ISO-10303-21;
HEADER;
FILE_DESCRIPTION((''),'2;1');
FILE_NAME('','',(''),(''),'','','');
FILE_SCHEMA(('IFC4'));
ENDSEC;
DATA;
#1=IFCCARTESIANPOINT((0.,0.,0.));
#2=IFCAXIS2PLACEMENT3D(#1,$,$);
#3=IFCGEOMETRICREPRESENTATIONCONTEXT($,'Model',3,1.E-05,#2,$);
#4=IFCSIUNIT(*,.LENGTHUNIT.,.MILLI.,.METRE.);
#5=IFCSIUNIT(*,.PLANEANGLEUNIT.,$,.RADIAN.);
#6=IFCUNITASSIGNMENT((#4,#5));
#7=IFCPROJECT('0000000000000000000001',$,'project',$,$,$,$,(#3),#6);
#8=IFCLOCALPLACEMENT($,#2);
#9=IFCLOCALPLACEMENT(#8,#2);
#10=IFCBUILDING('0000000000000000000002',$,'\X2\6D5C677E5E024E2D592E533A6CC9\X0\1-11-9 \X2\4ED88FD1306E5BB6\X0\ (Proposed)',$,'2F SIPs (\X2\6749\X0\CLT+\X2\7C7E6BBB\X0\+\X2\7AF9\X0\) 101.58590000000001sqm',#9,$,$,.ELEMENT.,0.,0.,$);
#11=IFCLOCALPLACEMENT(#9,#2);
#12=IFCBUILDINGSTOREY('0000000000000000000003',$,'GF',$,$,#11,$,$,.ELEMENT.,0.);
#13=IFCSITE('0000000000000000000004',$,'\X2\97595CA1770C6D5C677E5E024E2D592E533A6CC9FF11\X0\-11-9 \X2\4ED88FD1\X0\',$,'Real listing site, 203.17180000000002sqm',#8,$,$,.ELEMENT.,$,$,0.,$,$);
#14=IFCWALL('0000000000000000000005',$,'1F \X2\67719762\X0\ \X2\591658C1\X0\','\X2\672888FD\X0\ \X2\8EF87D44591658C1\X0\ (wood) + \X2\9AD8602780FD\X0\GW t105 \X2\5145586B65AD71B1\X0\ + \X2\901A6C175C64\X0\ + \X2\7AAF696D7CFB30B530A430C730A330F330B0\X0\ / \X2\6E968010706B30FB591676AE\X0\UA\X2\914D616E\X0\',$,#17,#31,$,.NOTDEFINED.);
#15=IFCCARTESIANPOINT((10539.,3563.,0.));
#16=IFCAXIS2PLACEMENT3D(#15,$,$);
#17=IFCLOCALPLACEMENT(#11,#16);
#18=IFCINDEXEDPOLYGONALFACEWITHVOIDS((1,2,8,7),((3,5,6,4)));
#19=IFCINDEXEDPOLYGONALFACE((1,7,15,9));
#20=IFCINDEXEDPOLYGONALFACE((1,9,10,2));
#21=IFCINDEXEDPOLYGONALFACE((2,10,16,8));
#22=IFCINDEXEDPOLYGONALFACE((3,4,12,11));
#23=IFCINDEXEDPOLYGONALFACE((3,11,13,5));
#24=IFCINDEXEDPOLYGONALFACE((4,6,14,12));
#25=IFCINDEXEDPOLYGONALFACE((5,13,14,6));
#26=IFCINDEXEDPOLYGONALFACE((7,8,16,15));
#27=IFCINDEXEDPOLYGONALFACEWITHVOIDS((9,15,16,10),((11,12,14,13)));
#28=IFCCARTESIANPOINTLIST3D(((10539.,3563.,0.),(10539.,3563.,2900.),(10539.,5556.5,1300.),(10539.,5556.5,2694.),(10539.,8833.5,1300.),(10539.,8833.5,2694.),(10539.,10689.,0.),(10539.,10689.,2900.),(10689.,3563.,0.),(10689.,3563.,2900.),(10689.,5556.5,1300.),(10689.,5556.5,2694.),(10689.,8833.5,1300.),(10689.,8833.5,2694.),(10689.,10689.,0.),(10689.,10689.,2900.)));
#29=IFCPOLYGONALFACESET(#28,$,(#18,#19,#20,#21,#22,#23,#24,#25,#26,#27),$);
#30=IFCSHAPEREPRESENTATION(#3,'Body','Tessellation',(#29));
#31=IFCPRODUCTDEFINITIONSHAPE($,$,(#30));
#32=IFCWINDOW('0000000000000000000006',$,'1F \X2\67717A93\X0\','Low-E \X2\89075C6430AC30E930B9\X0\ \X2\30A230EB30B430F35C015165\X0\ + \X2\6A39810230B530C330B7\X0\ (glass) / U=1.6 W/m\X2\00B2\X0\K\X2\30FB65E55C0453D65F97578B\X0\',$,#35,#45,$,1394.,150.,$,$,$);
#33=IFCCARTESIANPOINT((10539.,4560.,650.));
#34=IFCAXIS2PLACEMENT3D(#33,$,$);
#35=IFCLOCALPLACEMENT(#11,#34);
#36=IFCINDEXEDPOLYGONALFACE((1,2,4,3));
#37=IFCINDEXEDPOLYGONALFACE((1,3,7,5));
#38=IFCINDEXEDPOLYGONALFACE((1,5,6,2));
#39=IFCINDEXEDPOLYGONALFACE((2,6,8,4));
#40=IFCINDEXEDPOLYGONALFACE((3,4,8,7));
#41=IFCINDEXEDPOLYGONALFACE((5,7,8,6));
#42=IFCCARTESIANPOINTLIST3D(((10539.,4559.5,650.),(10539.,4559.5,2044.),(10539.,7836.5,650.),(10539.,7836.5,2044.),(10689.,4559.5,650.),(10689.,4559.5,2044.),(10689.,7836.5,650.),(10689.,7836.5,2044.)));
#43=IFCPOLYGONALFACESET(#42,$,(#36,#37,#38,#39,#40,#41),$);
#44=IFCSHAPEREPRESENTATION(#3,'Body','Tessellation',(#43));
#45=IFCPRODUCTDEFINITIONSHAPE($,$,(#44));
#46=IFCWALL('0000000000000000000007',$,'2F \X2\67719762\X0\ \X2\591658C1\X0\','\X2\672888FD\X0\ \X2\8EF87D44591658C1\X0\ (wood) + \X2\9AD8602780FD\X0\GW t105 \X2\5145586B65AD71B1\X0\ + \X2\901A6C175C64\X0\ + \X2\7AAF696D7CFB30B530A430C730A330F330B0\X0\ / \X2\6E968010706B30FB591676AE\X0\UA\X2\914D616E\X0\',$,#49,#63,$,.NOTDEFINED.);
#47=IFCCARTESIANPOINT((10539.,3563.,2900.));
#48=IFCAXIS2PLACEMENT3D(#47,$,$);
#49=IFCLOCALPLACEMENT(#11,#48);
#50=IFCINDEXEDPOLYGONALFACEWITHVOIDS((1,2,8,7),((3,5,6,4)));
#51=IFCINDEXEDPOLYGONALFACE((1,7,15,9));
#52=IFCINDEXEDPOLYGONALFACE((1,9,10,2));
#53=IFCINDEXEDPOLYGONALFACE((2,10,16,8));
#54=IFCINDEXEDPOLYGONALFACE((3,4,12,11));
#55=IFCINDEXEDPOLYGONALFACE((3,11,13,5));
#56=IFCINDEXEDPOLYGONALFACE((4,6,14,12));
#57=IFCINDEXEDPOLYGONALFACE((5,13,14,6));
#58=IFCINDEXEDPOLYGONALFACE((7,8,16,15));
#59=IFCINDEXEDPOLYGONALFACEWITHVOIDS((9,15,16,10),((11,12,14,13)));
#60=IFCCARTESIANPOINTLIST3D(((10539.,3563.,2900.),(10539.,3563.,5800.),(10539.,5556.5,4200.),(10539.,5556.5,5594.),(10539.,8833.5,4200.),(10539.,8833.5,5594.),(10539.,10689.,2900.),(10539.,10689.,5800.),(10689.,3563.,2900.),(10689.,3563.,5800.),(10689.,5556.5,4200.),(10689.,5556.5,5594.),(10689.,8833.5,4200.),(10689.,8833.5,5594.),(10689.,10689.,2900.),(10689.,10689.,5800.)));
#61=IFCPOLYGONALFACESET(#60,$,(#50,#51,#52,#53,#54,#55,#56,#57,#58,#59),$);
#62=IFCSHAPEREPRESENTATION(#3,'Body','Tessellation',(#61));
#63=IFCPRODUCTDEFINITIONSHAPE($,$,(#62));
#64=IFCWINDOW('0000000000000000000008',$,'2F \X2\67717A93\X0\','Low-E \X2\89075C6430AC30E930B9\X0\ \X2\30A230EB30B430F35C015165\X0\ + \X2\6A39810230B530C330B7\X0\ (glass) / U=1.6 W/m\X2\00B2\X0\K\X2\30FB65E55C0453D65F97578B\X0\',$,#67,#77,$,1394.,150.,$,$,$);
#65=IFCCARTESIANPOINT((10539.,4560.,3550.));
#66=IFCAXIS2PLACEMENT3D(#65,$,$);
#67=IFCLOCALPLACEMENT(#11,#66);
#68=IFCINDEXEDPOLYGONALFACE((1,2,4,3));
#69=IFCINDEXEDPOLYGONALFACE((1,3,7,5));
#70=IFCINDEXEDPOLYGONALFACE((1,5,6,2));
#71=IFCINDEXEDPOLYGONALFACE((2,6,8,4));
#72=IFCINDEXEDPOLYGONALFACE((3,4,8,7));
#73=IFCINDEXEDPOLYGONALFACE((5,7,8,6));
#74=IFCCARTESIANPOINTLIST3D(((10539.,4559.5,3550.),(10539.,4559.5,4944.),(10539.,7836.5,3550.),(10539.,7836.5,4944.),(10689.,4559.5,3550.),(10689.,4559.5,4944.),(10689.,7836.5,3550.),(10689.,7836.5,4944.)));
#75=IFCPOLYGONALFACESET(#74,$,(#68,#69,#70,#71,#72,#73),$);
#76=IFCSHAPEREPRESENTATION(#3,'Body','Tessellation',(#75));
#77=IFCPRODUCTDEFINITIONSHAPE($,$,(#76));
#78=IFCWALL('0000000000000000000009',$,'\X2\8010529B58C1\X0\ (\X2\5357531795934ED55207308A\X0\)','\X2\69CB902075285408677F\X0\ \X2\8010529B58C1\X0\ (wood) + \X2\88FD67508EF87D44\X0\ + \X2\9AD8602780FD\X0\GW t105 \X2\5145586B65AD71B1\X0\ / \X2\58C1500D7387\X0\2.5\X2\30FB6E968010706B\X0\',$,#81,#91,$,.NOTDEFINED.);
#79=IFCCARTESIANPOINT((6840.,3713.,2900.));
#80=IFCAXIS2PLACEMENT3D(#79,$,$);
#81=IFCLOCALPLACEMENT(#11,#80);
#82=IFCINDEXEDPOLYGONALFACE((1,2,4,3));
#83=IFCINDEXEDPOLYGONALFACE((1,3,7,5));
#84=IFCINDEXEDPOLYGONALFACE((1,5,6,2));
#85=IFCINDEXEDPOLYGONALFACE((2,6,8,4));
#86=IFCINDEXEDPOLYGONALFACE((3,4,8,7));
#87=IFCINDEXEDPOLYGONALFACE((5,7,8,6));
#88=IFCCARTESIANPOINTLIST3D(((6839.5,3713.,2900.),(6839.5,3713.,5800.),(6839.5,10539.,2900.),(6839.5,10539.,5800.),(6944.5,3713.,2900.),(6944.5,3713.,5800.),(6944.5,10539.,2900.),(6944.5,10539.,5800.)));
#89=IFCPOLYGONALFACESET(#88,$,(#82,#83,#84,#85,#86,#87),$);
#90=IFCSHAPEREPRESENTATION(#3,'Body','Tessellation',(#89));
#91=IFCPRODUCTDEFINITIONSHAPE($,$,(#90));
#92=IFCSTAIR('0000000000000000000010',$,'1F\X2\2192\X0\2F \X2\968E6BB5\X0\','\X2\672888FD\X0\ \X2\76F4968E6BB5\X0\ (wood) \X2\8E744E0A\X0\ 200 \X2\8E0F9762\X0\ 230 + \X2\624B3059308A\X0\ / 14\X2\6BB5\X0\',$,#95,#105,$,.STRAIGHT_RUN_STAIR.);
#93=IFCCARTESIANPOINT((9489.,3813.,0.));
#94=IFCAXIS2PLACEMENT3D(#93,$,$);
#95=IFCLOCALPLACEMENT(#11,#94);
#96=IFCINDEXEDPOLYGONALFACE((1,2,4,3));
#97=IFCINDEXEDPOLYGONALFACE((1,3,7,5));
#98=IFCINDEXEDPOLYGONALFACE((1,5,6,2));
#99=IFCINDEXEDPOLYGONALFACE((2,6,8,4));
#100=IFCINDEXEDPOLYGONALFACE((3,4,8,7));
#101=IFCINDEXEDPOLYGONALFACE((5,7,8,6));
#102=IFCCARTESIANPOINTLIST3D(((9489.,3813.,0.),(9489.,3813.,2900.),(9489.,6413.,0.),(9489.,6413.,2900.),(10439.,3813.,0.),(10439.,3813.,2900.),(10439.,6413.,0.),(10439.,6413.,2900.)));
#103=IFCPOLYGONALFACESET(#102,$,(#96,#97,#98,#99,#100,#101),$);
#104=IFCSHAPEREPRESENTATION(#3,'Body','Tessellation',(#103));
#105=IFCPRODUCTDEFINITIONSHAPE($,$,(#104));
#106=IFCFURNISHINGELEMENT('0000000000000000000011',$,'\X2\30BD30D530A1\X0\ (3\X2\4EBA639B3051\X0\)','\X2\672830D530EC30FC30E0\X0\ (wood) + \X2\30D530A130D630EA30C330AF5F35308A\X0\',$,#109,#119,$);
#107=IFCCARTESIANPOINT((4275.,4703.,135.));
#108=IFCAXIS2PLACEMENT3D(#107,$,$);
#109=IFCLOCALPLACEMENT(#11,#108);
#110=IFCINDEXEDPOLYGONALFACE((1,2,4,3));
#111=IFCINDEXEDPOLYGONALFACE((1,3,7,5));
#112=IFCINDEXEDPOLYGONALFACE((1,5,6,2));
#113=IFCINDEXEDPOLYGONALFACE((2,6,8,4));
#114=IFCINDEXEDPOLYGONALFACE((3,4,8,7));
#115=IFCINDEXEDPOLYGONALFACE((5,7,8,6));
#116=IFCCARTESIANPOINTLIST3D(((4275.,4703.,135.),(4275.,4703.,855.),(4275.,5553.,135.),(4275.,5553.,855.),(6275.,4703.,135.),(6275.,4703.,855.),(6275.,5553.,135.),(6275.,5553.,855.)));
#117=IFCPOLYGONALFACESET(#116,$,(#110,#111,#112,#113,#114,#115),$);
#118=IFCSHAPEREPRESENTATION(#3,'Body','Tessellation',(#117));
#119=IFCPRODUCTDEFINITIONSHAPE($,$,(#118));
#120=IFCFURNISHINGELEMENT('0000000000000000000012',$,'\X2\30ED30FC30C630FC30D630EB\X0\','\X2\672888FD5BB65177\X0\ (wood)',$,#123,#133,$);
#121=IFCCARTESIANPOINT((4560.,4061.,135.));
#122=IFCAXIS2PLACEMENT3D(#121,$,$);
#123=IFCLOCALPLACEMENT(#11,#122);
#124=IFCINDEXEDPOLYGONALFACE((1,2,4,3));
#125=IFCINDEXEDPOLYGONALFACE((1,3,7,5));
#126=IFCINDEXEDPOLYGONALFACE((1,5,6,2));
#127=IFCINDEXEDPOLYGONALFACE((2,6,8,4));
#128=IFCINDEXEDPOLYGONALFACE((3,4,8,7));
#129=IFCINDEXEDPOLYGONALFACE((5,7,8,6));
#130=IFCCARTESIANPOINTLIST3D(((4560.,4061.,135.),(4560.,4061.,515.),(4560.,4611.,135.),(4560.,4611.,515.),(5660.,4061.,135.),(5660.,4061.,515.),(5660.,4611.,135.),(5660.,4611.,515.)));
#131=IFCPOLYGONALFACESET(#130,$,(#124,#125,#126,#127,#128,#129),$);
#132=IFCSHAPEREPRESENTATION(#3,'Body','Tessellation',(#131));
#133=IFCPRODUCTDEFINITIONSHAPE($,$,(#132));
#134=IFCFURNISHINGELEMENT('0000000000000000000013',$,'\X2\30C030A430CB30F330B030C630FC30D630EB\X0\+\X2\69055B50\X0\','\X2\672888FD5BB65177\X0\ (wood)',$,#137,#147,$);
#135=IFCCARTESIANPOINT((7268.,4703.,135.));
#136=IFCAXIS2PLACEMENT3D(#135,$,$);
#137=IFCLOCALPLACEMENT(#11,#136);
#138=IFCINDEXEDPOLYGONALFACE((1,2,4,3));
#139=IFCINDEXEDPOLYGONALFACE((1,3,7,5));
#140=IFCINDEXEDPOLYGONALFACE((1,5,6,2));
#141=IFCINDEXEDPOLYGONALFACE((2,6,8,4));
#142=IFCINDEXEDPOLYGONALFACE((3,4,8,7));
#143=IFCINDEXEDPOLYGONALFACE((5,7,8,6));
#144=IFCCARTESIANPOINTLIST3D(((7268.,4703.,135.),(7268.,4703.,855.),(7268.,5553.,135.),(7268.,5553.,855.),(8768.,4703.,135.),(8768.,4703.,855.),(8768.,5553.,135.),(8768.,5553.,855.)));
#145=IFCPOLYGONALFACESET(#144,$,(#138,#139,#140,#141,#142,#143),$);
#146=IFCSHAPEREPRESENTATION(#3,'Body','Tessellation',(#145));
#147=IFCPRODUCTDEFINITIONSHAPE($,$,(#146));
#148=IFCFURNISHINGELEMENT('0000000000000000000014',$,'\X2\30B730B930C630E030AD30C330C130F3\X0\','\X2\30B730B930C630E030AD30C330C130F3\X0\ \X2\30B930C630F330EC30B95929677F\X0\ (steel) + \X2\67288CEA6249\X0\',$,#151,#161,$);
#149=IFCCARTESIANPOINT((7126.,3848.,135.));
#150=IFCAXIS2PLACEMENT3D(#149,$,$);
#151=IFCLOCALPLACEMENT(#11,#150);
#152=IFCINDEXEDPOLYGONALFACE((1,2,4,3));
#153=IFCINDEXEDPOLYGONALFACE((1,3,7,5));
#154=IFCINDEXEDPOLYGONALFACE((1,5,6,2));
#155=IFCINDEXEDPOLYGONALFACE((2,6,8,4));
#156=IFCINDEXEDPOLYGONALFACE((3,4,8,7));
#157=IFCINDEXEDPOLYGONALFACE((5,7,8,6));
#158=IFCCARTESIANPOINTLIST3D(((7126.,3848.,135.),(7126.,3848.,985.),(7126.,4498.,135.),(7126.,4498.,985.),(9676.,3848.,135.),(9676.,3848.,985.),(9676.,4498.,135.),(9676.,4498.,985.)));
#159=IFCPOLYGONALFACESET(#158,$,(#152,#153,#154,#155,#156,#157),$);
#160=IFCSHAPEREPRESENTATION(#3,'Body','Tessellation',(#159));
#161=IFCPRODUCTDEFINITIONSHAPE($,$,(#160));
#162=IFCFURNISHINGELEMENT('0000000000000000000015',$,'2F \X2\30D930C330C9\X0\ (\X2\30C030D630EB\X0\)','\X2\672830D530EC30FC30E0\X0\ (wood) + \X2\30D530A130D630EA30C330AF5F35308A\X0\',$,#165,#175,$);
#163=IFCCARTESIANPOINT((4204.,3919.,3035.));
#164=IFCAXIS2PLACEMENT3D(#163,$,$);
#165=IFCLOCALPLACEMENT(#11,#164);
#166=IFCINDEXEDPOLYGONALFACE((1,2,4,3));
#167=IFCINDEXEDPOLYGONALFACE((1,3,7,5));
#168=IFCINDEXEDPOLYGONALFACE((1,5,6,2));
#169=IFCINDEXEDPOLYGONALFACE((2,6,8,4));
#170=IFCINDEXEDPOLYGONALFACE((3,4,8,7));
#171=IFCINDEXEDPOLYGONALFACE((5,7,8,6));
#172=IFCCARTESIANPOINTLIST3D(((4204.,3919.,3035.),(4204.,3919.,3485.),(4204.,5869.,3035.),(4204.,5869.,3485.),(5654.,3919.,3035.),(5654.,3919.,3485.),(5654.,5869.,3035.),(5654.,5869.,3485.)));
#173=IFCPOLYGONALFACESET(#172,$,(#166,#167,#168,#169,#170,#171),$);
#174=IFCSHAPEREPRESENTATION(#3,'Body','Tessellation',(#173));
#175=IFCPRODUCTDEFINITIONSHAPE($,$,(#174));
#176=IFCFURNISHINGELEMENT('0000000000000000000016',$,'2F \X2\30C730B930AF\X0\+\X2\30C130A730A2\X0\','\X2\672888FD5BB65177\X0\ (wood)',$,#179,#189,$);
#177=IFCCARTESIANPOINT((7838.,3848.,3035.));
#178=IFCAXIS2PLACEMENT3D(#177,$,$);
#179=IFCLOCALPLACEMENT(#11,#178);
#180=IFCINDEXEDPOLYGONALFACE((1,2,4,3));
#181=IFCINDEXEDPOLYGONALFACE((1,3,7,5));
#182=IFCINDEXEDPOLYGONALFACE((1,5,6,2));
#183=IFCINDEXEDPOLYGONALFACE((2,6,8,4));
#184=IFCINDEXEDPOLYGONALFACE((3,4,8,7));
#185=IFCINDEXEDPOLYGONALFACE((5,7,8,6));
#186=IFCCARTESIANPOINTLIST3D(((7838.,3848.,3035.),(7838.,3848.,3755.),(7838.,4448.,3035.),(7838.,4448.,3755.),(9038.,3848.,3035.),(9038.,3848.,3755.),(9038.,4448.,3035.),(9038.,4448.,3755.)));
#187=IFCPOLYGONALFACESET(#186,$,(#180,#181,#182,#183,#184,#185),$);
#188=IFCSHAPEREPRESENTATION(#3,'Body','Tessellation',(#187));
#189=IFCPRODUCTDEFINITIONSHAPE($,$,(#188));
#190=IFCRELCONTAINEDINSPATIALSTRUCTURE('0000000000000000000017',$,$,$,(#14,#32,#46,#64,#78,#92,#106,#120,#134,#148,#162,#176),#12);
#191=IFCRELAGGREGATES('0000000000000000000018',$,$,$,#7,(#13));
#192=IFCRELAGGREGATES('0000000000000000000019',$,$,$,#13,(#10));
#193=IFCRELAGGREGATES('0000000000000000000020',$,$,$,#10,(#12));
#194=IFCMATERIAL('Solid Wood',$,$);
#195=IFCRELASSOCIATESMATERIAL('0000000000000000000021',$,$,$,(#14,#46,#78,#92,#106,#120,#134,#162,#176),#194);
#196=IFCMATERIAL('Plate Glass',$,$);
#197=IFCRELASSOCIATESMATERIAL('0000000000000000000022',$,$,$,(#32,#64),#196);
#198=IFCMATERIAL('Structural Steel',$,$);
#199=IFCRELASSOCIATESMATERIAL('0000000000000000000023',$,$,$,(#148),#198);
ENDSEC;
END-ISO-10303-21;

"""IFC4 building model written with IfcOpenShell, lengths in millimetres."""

from ifc_helpers import new_model, si_unit, frame, frame_2d, origin, place, context, project, spatial, rectangle, extrude, material, element, fill, save


model = new_model("IFC4")

# Units and contexts
model_context = context("Model", 3, precision=1e-05, world=origin())
ifc_project = project(units=[si_unit("LENGTHUNIT", "METRE", prefix="MILLI"), si_unit("PLANEANGLEUNIT", "RADIAN")], contexts=[model_context])

# Site, building, storey
site_placement = place(None, origin())
site = spatial("IfcSite", under=ifc_project, at=site_placement, Name="静岡県浜松市中央区泉１-11-9 付近", ObjectType="Real listing site, 203.17180000000002sqm", CompositionType="ELEMENT", RefElevation=0.0)
building_placement = place(site_placement, origin())
building = spatial("IfcBuilding", under=site, at=building_placement, Name="浜松市中央区泉1-11-9 付近の家 (Proposed)", ObjectType="2F SIPs (杉CLT+籾殻+竹) 101.58590000000001sqm", CompositionType="ELEMENT", ElevationOfRefHeight=0.0, ElevationOfTerrain=0.0)
storey_placement = place(building_placement, origin())
storey = spatial("IfcBuildingStorey", under=building, at=storey_placement, Name="GF", CompositionType="ELEMENT", Elevation=0.0)

# Wall, opening, window
ifc_material_1 = material(Name="Solid Wood")
wall_1_placement = place(storey_placement, frame((10539.0, 3563.0, 0.0)))
wall_1 = element("IfcWall", 1, at=wall_1_placement, inside=storey, material=ifc_material_1, Name="1F 東面 外壁", Description="木製 軸組外壁 (wood) + 高性能GW t105 充填断熱 + 通気層 + 窯業系サイディング / 準耐火・外皮UA配慮", PredefinedType="NOTDEFINED", context=model_context, shape_type="SweptSolid", body=[
    extrude(rectangle(XDim=150.0, YDim=7126.0, at=frame_2d((75.0, 3563.0))), frame((10539.0, 3563.0, 0.0)), (0.0, 0.0, 1.0), 2900.0),
])
opening_1_placement = place(storey_placement, frame((10539.0, 4560.0, 650.0)))
opening_1 = element("IfcOpeningElement", 2, at=opening_1_placement, cuts=wall_1, PredefinedType="NOTDEFINED", context=model_context, shape_type="SweptSolid", body=[
    extrude(rectangle(XDim=150.0, YDim=3277.0, at=frame_2d((75.0, 1638.0))), frame((10539.0, 4560.0, 650.0)), (0.0, 0.0, 1.0), 1394.0),
])
ifc_material_2 = material(Name="Plate Glass")
window_1_placement = place(storey_placement, frame((10539.0, 4560.0, 650.0)))
window_1 = element("IfcWindow", 3, at=window_1_placement, inside=storey, material=ifc_material_2, Name="1F 東窓", Description="Low-E 複層ガラス アルゴン封入 + 樹脂サッシ (glass) / U=1.6 W/m²K・日射取得型", OverallHeight=1394.0, OverallWidth=150.0, context=model_context, shape_type="SweptSolid", body=[
    extrude(rectangle(XDim=150.0, YDim=3277.0, at=frame_2d((75.0, 1638.0))), frame((10539.0, 4560.0, 650.0)), (0.0, 0.0, 1.0), 1394.0),
])
fill(opening_1, window_1)

# Wall, opening, window
wall_2_placement = place(storey_placement, frame((10539.0, 3563.0, 2900.0)))
wall_2 = element("IfcWall", 4, at=wall_2_placement, inside=storey, material=ifc_material_1, Name="2F 東面 外壁", Description="木製 軸組外壁 (wood) + 高性能GW t105 充填断熱 + 通気層 + 窯業系サイディング / 準耐火・外皮UA配慮", PredefinedType="NOTDEFINED", context=model_context, shape_type="SweptSolid", body=[
    extrude(rectangle(XDim=150.0, YDim=7126.0, at=frame_2d((75.0, 3563.0))), frame((10539.0, 3563.0, 2900.0)), (0.0, 0.0, 1.0), 2900.0),
])
opening_2_placement = place(storey_placement, frame((10539.0, 4560.0, 3550.0)))
opening_2 = element("IfcOpeningElement", 5, at=opening_2_placement, cuts=wall_2, PredefinedType="NOTDEFINED", context=model_context, shape_type="SweptSolid", body=[
    extrude(rectangle(XDim=150.0, YDim=3277.0, at=frame_2d((75.0, 1638.0))), frame((10539.0, 4560.0, 3550.0)), (0.0, 0.0, 1.0), 1394.0),
])
window_2_placement = place(storey_placement, frame((10539.0, 4560.0, 3550.0)))
window_2 = element("IfcWindow", 6, at=window_2_placement, inside=storey, material=ifc_material_2, Name="2F 東窓", Description="Low-E 複層ガラス アルゴン封入 + 樹脂サッシ (glass) / U=1.6 W/m²K・日射取得型", OverallHeight=1394.0, OverallWidth=150.0, context=model_context, shape_type="SweptSolid", body=[
    extrude(rectangle(XDim=150.0, YDim=3277.0, at=frame_2d((75.0, 1638.0))), frame((10539.0, 4560.0, 3550.0)), (0.0, 0.0, 1.0), 1394.0),
])
fill(opening_2, window_2)

# Wall
wall_3_placement = place(storey_placement, frame((6840.0, 3713.0, 2900.0)))
element("IfcWall", 7, at=wall_3_placement, inside=storey, material=ifc_material_1, Name="耐力壁 (南北間仕切り)", Description="構造用合板 耐力壁 (wood) + 製材軸組 + 高性能GW t105 充填断熱 / 壁倍率2.5・準耐火", PredefinedType="NOTDEFINED", context=model_context, shape_type="SweptSolid", body=[
    extrude(rectangle(XDim=105.0, YDim=6826.0, at=frame_2d((52.0, 3413.0))), frame((6840.0, 3713.0, 2900.0)), (0.0, 0.0, 1.0), 2900.0),
])

# Stair
stair_placement = place(storey_placement, frame((9489.0, 3813.0, 0.0)))
element("IfcStair", 8, at=stair_placement, inside=storey, material=ifc_material_1, Name="1F→2F 階段", Description="木製 直階段 (wood) 蹴上 200 踏面 230 + 手すり / 14段", PredefinedType="STRAIGHT_RUN_STAIR", context=model_context, shape_type="SweptSolid", body=[
    extrude(rectangle(XDim=950.0, YDim=2600.0, at=frame_2d((475.0, 1300.0))), frame((9489.0, 3813.0, 0.0)), (0.0, 0.0, 1.0), 2900.0),
])

# Furnishing elements
furnishing_1_placement = place(storey_placement, frame((4275.0, 4703.0, 135.0)))
element("IfcFurnishingElement", 9, at=furnishing_1_placement, inside=storey, material=ifc_material_1, Name="ソファ (3人掛け)", Description="木フレーム (wood) + ファブリック張り", context=model_context, shape_type="SweptSolid", body=[
    extrude(rectangle(XDim=2000.0, YDim=850.0, at=frame_2d((1000.0, 425.0))), frame((4275.0, 4703.0, 135.0)), (0.0, 0.0, 1.0), 720.0),
])
furnishing_2_placement = place(storey_placement, frame((4560.0, 4061.0, 135.0)))
element("IfcFurnishingElement", 10, at=furnishing_2_placement, inside=storey, material=ifc_material_1, Name="ローテーブル", Description="木製家具 (wood)", context=model_context, shape_type="SweptSolid", body=[
    extrude(rectangle(XDim=1100.0, YDim=550.0, at=frame_2d((550.0, 275.0))), frame((4560.0, 4061.0, 135.0)), (0.0, 0.0, 1.0), 380.0),
])
furnishing_3_placement = place(storey_placement, frame((7268.0, 4703.0, 135.0)))
element("IfcFurnishingElement", 11, at=furnishing_3_placement, inside=storey, material=ifc_material_1, Name="ダイニングテーブル+椅子", Description="木製家具 (wood)", context=model_context, shape_type="SweptSolid", body=[
    extrude(rectangle(XDim=1500.0, YDim=850.0, at=frame_2d((750.0, 425.0))), frame((7268.0, 4703.0, 135.0)), (0.0, 0.0, 1.0), 720.0),
])
ifc_material_3 = material(Name="Structural Steel")
furnishing_4_placement = place(storey_placement, frame((7126.0, 3848.0, 135.0)))
element("IfcFurnishingElement", 12, at=furnishing_4_placement, inside=storey, material=ifc_material_3, Name="システムキッチン", Description="システムキッチン ステンレス天板 (steel) + 木質扉", context=model_context, shape_type="SweptSolid", body=[
    extrude(rectangle(XDim=2550.0, YDim=650.0, at=frame_2d((1275.0, 325.0))), frame((7126.0, 3848.0, 135.0)), (0.0, 0.0, 1.0), 850.0),
])
furnishing_5_placement = place(storey_placement, frame((4204.0, 3919.0, 3035.0)))
element("IfcFurnishingElement", 13, at=furnishing_5_placement, inside=storey, material=ifc_material_1, Name="2F ベッド (ダブル)", Description="木フレーム (wood) + ファブリック張り", context=model_context, shape_type="SweptSolid", body=[
    extrude(rectangle(XDim=1450.0, YDim=1950.0, at=frame_2d((725.0, 975.0))), frame((4204.0, 3919.0, 3035.0)), (0.0, 0.0, 1.0), 450.0),
])
furnishing_6_placement = place(storey_placement, frame((7838.0, 3848.0, 3035.0)))
element("IfcFurnishingElement", 14, at=furnishing_6_placement, inside=storey, material=ifc_material_1, Name="2F デスク+チェア", Description="木製家具 (wood)", context=model_context, shape_type="SweptSolid", body=[
    extrude(rectangle(XDim=1200.0, YDim=600.0, at=frame_2d((600.0, 300.0))), frame((7838.0, 3848.0, 3035.0)), (0.0, 0.0, 1.0), 720.0),
])

save(model, "model.ifc")
